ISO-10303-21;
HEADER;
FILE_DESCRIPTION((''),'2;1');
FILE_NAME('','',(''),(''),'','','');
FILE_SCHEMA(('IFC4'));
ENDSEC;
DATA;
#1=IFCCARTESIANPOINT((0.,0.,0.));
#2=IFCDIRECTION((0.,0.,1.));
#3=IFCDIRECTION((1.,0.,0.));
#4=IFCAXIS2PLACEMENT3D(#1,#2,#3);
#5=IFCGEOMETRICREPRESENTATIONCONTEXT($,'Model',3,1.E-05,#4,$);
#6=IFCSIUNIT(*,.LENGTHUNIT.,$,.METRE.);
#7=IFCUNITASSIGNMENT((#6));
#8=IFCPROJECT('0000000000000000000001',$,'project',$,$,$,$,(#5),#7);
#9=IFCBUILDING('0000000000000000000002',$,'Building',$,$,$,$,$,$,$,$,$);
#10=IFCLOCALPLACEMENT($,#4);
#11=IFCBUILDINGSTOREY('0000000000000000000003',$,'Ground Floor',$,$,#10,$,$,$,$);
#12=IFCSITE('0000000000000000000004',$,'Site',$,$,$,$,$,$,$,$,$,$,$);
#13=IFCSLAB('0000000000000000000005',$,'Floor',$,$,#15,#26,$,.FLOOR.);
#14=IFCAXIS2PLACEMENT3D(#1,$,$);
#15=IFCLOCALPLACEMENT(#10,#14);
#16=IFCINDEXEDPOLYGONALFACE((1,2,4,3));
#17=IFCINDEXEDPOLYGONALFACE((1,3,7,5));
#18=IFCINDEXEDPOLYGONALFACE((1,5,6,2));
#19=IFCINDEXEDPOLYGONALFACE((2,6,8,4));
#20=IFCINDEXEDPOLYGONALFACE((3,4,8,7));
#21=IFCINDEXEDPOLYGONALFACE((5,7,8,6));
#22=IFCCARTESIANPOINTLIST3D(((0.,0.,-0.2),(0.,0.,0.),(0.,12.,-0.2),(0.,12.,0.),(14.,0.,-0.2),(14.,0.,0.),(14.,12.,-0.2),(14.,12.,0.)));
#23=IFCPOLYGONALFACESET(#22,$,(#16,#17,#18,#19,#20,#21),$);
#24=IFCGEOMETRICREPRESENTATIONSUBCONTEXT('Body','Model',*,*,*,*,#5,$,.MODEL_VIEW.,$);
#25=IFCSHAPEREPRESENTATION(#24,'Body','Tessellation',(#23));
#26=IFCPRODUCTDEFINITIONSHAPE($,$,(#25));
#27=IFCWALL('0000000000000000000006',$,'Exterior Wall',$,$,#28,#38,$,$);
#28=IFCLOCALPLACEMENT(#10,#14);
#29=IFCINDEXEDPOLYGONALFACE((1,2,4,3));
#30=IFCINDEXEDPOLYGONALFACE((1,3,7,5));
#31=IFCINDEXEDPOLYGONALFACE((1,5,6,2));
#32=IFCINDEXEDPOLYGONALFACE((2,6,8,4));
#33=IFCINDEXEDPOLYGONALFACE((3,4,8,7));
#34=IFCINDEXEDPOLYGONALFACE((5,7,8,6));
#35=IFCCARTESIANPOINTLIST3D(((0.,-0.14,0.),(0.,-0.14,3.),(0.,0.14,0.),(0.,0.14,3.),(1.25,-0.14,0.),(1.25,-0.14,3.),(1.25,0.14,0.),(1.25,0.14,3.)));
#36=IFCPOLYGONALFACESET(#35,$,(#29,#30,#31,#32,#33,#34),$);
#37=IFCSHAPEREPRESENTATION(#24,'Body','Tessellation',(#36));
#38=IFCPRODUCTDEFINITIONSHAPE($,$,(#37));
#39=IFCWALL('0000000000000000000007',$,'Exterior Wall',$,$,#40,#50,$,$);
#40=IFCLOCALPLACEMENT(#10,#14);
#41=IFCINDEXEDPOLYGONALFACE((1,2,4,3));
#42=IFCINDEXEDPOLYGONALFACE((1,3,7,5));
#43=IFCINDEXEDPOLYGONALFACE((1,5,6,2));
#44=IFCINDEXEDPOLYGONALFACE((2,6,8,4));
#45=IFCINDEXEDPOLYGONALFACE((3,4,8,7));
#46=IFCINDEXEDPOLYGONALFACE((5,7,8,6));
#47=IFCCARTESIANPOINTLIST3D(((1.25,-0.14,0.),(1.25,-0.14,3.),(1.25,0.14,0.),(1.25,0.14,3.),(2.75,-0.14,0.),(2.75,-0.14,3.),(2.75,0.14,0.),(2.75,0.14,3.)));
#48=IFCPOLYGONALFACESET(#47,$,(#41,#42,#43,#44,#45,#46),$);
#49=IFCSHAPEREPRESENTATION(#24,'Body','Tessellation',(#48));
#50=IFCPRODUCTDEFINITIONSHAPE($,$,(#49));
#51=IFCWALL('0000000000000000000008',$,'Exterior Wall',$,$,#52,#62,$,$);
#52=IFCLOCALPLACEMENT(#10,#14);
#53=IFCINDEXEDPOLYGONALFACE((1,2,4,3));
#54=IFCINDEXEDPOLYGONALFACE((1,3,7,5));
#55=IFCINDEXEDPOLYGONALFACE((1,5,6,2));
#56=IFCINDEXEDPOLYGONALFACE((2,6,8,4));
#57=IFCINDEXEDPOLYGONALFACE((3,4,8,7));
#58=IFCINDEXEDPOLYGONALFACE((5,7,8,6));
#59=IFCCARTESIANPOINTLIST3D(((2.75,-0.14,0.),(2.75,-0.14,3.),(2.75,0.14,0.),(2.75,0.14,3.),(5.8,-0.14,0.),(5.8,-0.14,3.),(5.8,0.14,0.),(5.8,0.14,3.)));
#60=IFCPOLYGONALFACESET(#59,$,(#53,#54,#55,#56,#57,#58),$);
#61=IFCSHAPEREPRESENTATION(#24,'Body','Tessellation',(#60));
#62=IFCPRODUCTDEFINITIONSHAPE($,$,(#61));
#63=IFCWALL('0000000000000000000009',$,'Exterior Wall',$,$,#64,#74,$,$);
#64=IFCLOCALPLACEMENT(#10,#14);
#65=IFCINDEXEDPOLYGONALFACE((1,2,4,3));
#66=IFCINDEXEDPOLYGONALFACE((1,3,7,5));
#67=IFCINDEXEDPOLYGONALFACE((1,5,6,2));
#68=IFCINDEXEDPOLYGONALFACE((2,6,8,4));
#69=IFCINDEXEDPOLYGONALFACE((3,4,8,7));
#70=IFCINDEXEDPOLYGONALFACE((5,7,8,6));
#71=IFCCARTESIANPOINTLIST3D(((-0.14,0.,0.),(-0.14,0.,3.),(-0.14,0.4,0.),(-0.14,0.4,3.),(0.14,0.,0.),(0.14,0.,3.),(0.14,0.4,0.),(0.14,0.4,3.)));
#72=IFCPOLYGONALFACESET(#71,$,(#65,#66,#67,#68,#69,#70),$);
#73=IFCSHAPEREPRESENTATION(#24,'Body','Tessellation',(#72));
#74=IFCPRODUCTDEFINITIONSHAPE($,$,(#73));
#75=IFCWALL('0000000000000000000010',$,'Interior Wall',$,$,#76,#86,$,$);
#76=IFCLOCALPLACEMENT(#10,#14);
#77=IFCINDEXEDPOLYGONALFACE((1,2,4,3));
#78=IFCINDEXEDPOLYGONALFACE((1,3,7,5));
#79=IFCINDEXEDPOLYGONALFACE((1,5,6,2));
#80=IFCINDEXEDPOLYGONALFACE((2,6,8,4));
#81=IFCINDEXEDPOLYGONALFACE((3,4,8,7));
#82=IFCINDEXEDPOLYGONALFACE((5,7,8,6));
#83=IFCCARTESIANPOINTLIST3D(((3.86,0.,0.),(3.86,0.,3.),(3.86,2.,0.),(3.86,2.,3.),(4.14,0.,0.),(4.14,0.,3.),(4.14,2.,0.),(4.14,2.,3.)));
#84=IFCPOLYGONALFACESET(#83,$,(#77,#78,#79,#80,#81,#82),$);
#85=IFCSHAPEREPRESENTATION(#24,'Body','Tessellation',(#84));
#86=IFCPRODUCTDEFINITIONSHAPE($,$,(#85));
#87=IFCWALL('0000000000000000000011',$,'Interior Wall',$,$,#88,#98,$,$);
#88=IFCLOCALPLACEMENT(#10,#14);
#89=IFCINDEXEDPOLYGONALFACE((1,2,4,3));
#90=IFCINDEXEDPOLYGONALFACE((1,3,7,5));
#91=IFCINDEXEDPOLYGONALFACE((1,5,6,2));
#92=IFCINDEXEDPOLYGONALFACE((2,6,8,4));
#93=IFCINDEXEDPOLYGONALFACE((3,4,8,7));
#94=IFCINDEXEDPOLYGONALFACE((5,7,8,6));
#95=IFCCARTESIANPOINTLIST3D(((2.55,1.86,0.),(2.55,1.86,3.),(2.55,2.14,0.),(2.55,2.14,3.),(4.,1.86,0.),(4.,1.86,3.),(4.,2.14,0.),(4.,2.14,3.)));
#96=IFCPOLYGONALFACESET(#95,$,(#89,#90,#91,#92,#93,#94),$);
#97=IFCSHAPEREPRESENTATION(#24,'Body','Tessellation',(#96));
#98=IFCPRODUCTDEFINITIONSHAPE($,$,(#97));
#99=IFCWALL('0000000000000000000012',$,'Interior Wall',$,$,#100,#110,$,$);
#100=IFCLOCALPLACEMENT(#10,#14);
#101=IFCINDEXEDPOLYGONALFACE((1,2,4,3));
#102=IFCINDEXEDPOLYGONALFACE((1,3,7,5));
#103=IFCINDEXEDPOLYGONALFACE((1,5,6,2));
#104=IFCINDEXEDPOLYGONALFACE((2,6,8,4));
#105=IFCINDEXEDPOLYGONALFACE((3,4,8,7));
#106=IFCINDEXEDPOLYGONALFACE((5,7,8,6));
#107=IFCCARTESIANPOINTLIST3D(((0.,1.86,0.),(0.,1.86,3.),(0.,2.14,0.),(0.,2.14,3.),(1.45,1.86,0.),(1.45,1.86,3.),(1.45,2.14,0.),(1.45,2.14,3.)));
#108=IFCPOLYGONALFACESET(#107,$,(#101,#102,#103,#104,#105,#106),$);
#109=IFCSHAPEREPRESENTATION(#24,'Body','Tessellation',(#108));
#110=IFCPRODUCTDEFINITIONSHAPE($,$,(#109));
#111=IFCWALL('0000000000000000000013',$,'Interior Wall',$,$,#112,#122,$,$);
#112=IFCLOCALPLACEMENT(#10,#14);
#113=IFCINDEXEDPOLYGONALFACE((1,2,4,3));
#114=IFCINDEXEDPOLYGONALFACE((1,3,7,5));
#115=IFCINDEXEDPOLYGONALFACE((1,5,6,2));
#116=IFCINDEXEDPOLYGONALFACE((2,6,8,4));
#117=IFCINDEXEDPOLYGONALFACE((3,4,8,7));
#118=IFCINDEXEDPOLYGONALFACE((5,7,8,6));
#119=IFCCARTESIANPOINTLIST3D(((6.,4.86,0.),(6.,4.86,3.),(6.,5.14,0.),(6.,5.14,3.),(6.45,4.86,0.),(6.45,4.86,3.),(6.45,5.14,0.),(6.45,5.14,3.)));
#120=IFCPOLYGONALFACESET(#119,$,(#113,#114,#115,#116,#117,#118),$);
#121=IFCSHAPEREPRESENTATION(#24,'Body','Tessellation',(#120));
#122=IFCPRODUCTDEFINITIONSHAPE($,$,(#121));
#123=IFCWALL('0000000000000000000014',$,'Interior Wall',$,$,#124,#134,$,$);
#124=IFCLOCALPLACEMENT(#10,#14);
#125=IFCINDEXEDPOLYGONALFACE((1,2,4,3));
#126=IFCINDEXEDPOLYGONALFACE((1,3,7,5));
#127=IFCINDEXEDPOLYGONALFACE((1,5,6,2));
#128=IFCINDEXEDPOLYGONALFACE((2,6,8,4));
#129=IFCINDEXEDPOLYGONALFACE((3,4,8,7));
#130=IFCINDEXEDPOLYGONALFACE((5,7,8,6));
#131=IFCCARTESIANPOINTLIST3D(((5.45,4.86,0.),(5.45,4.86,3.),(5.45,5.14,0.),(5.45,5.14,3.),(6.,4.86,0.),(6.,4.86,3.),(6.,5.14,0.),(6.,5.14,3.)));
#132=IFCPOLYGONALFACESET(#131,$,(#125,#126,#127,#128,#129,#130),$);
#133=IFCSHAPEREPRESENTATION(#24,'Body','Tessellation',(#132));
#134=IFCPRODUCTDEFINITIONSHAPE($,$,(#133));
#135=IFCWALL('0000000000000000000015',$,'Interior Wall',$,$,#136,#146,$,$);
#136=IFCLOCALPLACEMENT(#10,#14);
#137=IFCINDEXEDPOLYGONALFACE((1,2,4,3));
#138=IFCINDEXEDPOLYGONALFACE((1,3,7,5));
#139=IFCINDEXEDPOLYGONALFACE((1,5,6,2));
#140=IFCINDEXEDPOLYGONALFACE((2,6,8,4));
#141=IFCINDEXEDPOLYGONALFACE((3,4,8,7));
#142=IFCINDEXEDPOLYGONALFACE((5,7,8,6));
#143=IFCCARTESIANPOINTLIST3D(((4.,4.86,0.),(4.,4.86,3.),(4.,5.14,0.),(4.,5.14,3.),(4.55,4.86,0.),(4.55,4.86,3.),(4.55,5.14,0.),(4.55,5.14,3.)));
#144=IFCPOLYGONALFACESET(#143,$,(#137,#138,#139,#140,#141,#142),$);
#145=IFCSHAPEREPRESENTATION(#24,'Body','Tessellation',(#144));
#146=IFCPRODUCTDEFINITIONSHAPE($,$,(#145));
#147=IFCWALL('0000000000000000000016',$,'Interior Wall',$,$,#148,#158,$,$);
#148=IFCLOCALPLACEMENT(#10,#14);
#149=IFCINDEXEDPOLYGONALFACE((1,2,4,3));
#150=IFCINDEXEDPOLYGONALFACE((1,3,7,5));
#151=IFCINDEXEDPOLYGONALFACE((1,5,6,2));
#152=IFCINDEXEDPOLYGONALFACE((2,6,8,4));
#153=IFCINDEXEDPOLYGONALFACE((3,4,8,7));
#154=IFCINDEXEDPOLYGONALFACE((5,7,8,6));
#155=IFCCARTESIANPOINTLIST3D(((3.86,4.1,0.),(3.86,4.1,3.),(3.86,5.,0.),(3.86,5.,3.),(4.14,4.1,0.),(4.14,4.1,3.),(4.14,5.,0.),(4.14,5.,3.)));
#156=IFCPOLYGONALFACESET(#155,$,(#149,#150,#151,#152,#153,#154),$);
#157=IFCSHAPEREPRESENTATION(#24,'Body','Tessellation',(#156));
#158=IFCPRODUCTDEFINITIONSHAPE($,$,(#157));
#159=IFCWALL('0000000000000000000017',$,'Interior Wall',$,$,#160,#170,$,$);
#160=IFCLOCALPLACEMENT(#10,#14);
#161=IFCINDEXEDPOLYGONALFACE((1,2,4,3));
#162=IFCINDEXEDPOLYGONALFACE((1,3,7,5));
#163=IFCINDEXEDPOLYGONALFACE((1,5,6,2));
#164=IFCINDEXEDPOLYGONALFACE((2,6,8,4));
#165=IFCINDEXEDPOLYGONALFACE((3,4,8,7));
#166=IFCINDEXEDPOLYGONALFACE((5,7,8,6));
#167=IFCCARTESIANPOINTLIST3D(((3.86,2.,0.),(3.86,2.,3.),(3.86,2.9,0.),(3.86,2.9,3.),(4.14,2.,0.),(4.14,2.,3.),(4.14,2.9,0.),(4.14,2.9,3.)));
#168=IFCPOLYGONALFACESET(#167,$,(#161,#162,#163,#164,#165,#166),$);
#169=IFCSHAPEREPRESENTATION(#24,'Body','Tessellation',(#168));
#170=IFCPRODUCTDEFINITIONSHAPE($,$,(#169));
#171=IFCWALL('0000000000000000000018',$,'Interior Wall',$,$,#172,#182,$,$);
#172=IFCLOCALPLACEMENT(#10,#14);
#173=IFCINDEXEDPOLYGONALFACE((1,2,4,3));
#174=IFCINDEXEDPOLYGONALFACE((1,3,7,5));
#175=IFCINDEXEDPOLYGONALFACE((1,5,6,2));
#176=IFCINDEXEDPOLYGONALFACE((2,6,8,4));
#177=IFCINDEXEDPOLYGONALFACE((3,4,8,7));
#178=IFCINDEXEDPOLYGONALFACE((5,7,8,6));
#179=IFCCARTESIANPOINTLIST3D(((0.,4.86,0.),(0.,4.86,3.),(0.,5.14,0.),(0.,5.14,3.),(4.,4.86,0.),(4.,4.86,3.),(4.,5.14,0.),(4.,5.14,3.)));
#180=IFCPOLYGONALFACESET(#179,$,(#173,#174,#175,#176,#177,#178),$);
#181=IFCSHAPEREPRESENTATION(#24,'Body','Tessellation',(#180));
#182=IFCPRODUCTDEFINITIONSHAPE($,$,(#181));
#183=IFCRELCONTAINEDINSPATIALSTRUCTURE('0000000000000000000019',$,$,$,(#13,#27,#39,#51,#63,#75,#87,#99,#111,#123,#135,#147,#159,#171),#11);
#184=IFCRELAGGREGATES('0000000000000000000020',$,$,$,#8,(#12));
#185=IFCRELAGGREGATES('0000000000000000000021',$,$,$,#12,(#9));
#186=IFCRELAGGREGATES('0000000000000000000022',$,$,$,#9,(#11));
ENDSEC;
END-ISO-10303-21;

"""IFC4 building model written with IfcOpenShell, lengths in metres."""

from ifc_helpers import new_model, si_unit, frame, origin_with_axes, place, context, subcontext, project, spatial, indexed_curve, outline, extrude, element, save


model = new_model("IFC4")

# Units and contexts
model_context = context("Model", 3, precision=1e-05, world=origin_with_axes())
body_context = subcontext(model_context, "Body", "Model", "MODEL_VIEW")
ifc_project = project(units=[si_unit("LENGTHUNIT", "METRE")], contexts=[model_context])

# Site, building, storey
site = spatial("IfcSite", under=ifc_project, Name="Site")
building = spatial("IfcBuilding", under=site, Name="Building")
storey_placement = place(None, origin_with_axes())
storey = spatial("IfcBuildingStorey", under=building, at=storey_placement, Name="Ground Floor")

# Slab
slab_placement = place(storey_placement, frame((0.0, 0.0, -0.2), z_axis=(0.0, 0.0, 1.0), x_axis=(1.0, 0.0, 0.0)))
element("IfcSlab", 1, at=slab_placement, inside=storey, Name="Floor", PredefinedType="FLOOR", context=body_context, shape_type="SweptSolid", body=[
    extrude(outline(indexed_curve([(0.0, 0.0), (14.0, 0.0), (14.0, 12.0), (0.0, 12.0)])), None, (0.0, 0.0, 1.0), 0.2),
])

# Walls
wall_1_placement = place(storey_placement, origin_with_axes())
element("IfcWall", 2, at=wall_1_placement, inside=storey, Name="Exterior Wall", context=body_context, shape_type="SweptSolid", body=[
    extrude(outline(indexed_curve([(0.0, 0.0), (0.0, 0.28), (1.25, 0.28), (1.25, 0.0), (0.0, 0.0)], self_intersect=False)), frame((0.0, -0.14, 0.0), z_axis=(0.0, 0.0, 1.0), x_axis=(1.0, 0.0, 0.0)), (0.0, 0.0, 1.0), 3.0),
])
wall_2_placement = place(storey_placement, frame((2.75, 0.0, 0.0), z_axis=(0.0, 0.0, 1.0), x_axis=(-1.0, 0.0, 0.0)))
element("IfcWall", 3, at=wall_2_placement, inside=storey, Name="Exterior Wall", context=body_context, shape_type="SweptSolid", body=[
    extrude(outline(indexed_curve([(0.0, 0.0), (0.0, 0.28), (1.5, 0.28), (1.5, 0.0), (0.0, 0.0)], self_intersect=False)), frame((0.0, -0.14, 0.0), z_axis=(0.0, 0.0, 1.0), x_axis=(1.0, 0.0, 0.0)), (0.0, 0.0, 1.0), 3.0),
])
wall_3_placement = place(storey_placement, frame((2.75, 0.0, 0.0), z_axis=(0.0, 0.0, 1.0), x_axis=(1.0, 0.0, 0.0)))
element("IfcWall", 4, at=wall_3_placement, inside=storey, Name="Exterior Wall", context=body_context, shape_type="SweptSolid", body=[
    extrude(outline(indexed_curve([(0.0, 0.0), (0.0, 0.28), (3.05, 0.28), (3.05, 0.0), (0.0, 0.0)], self_intersect=False)), frame((0.0, -0.14, 0.0), z_axis=(0.0, 0.0, 1.0), x_axis=(1.0, 0.0, 0.0)), (0.0, 0.0, 1.0), 3.0),
])
wall_4_placement = place(storey_placement, frame((0.0, 0.4, 0.0), z_axis=(0.0, 0.0, 1.0), x_axis=(0.0, -1.0, 0.0)))
element("IfcWall", 5, at=wall_4_placement, inside=storey, Name="Exterior Wall", context=body_context, shape_type="SweptSolid", body=[
    extrude(outline(indexed_curve([(0.0, 0.0), (0.0, 0.28), (0.4, 0.28), (0.4, 0.0), (0.0, 0.0)], self_intersect=False)), frame((0.0, -0.14, 0.0), z_axis=(0.0, 0.0, 1.0), x_axis=(1.0, 0.0, 0.0)), (0.0, 0.0, 1.0), 3.0),
])
wall_5_placement = place(storey_placement, frame((4.0, 0.0, 0.0), z_axis=(0.0, 0.0, 1.0), x_axis=(0.0, 1.0, 0.0)))
element("IfcWall", 6, at=wall_5_placement, inside=storey, Name="Interior Wall", context=body_context, shape_type="SweptSolid", body=[
    extrude(outline(indexed_curve([(0.0, 0.0), (0.0, 0.28), (2.0, 0.28), (2.0, 0.0), (0.0, 0.0)], self_intersect=False)), frame((0.0, -0.14, 0.0), z_axis=(0.0, 0.0, 1.0), x_axis=(1.0, 0.0, 0.0)), (0.0, 0.0, 1.0), 3.0),
])
for number, where, z_axis, x_axis, name in (
    (7, (4.0, 2.0, 0.0), (0.0, 0.0, 1.0), (-1.0, 0.0, 0.0), "Interior Wall"),
    (8, (1.45, 2.0, 0.0), (0.0, 0.0, 1.0), (-1.0, 0.0, 0.0), "Interior Wall"),
):
    element("IfcWall", number, at=place(storey_placement, frame(where, z_axis=z_axis, x_axis=x_axis)), inside=storey, Name=name, context=body_context, shape_type="SweptSolid", body=[
        extrude(outline(indexed_curve([(0.0, 0.0), (0.0, 0.28), (1.45, 0.28), (1.45, 0.0), (0.0, 0.0)], self_intersect=False)), frame((0.0, -0.14, 0.0), z_axis=(0.0, 0.0, 1.0), x_axis=(1.0, 0.0, 0.0)), (0.0, 0.0, 1.0), 3.0),
    ])
wall_6_placement = place(storey_placement, frame((6.45, 5.0, 0.0), z_axis=(0.0, 0.0, 1.0), x_axis=(-1.0, 0.0, 0.0)))
element("IfcWall", 9, at=wall_6_placement, inside=storey, Name="Interior Wall", context=body_context, shape_type="SweptSolid", body=[
    extrude(outline(indexed_curve([(0.0, 0.0), (0.0, 0.28), (0.45, 0.28), (0.45, 0.0), (0.0, 0.0)], self_intersect=False)), frame((0.0, -0.14, 0.0), z_axis=(0.0, 0.0, 1.0), x_axis=(1.0, 0.0, 0.0)), (0.0, 0.0, 1.0), 3.0),
])
for number, where, z_axis, x_axis, name in (
    (10, (6.0, 5.0, 0.0), (0.0, 0.0, 1.0), (-1.0, 0.0, 0.0), "Interior Wall"),
    (11, (4.55, 5.0, 0.0), (0.0, 0.0, 1.0), (-1.0, 0.0, 0.0), "Interior Wall"),
):
    element("IfcWall", number, at=place(storey_placement, frame(where, z_axis=z_axis, x_axis=x_axis)), inside=storey, Name=name, context=body_context, shape_type="SweptSolid", body=[
        extrude(outline(indexed_curve([(0.0, 0.0), (0.0, 0.28), (0.55, 0.28), (0.55, 0.0), (0.0, 0.0)], self_intersect=False)), frame((0.0, -0.14, 0.0), z_axis=(0.0, 0.0, 1.0), x_axis=(1.0, 0.0, 0.0)), (0.0, 0.0, 1.0), 3.0),
    ])
wall_7_placement = place(storey_placement, frame((4.0, 5.0, 0.0), z_axis=(0.0, 0.0, 1.0), x_axis=(0.0, -1.0, 0.0)))
element("IfcWall", 12, at=wall_7_placement, inside=storey, Name="Interior Wall", context=body_context, shape_type="SweptSolid", body=[
    extrude(outline(indexed_curve([(0.0, 0.0), (0.0, 0.28), (0.9, 0.28), (0.9, 0.0), (0.0, 0.0)], self_intersect=False)), frame((0.0, -0.14, 0.0), z_axis=(0.0, 0.0, 1.0), x_axis=(1.0, 0.0, 0.0)), (0.0, 0.0, 1.0), 3.0),
])
wall_8_placement = place(storey_placement, frame((4.0, 2.9, 0.0), z_axis=(0.0, 0.0, 1.0), x_axis=(0.0, -1.0, 0.0)))
element("IfcWall", 13, at=wall_8_placement, inside=storey, Name="Interior Wall", context=body_context, shape_type="SweptSolid", body=[
    extrude(outline(indexed_curve([(0.0, 0.0), (0.0, 0.28), (0.9, 0.28), (0.9, 0.0), (0.0, 0.0)], self_intersect=False)), frame((0.0, -0.14, 0.0), z_axis=(0.0, 0.0, 1.0), x_axis=(1.0, 0.0, 0.0)), (0.0, 0.0, 1.0), 3.0),
])
wall_9_placement = place(storey_placement, frame((4.0, 5.0, 0.0), z_axis=(0.0, 0.0, 1.0), x_axis=(-1.0, 0.0, 0.0)))
element("IfcWall", 14, at=wall_9_placement, inside=storey, Name="Interior Wall", context=body_context, shape_type="SweptSolid", body=[
    extrude(outline(indexed_curve([(0.0, 0.0), (0.0, 0.28), (4.0, 0.28), (4.0, 0.0), (0.0, 0.0)], self_intersect=False)), frame((0.0, -0.14, 0.0), z_axis=(0.0, 0.0, 1.0), x_axis=(1.0, 0.0, 0.0)), (0.0, 0.0, 1.0), 3.0),
])

save(model, "model.ifc")
